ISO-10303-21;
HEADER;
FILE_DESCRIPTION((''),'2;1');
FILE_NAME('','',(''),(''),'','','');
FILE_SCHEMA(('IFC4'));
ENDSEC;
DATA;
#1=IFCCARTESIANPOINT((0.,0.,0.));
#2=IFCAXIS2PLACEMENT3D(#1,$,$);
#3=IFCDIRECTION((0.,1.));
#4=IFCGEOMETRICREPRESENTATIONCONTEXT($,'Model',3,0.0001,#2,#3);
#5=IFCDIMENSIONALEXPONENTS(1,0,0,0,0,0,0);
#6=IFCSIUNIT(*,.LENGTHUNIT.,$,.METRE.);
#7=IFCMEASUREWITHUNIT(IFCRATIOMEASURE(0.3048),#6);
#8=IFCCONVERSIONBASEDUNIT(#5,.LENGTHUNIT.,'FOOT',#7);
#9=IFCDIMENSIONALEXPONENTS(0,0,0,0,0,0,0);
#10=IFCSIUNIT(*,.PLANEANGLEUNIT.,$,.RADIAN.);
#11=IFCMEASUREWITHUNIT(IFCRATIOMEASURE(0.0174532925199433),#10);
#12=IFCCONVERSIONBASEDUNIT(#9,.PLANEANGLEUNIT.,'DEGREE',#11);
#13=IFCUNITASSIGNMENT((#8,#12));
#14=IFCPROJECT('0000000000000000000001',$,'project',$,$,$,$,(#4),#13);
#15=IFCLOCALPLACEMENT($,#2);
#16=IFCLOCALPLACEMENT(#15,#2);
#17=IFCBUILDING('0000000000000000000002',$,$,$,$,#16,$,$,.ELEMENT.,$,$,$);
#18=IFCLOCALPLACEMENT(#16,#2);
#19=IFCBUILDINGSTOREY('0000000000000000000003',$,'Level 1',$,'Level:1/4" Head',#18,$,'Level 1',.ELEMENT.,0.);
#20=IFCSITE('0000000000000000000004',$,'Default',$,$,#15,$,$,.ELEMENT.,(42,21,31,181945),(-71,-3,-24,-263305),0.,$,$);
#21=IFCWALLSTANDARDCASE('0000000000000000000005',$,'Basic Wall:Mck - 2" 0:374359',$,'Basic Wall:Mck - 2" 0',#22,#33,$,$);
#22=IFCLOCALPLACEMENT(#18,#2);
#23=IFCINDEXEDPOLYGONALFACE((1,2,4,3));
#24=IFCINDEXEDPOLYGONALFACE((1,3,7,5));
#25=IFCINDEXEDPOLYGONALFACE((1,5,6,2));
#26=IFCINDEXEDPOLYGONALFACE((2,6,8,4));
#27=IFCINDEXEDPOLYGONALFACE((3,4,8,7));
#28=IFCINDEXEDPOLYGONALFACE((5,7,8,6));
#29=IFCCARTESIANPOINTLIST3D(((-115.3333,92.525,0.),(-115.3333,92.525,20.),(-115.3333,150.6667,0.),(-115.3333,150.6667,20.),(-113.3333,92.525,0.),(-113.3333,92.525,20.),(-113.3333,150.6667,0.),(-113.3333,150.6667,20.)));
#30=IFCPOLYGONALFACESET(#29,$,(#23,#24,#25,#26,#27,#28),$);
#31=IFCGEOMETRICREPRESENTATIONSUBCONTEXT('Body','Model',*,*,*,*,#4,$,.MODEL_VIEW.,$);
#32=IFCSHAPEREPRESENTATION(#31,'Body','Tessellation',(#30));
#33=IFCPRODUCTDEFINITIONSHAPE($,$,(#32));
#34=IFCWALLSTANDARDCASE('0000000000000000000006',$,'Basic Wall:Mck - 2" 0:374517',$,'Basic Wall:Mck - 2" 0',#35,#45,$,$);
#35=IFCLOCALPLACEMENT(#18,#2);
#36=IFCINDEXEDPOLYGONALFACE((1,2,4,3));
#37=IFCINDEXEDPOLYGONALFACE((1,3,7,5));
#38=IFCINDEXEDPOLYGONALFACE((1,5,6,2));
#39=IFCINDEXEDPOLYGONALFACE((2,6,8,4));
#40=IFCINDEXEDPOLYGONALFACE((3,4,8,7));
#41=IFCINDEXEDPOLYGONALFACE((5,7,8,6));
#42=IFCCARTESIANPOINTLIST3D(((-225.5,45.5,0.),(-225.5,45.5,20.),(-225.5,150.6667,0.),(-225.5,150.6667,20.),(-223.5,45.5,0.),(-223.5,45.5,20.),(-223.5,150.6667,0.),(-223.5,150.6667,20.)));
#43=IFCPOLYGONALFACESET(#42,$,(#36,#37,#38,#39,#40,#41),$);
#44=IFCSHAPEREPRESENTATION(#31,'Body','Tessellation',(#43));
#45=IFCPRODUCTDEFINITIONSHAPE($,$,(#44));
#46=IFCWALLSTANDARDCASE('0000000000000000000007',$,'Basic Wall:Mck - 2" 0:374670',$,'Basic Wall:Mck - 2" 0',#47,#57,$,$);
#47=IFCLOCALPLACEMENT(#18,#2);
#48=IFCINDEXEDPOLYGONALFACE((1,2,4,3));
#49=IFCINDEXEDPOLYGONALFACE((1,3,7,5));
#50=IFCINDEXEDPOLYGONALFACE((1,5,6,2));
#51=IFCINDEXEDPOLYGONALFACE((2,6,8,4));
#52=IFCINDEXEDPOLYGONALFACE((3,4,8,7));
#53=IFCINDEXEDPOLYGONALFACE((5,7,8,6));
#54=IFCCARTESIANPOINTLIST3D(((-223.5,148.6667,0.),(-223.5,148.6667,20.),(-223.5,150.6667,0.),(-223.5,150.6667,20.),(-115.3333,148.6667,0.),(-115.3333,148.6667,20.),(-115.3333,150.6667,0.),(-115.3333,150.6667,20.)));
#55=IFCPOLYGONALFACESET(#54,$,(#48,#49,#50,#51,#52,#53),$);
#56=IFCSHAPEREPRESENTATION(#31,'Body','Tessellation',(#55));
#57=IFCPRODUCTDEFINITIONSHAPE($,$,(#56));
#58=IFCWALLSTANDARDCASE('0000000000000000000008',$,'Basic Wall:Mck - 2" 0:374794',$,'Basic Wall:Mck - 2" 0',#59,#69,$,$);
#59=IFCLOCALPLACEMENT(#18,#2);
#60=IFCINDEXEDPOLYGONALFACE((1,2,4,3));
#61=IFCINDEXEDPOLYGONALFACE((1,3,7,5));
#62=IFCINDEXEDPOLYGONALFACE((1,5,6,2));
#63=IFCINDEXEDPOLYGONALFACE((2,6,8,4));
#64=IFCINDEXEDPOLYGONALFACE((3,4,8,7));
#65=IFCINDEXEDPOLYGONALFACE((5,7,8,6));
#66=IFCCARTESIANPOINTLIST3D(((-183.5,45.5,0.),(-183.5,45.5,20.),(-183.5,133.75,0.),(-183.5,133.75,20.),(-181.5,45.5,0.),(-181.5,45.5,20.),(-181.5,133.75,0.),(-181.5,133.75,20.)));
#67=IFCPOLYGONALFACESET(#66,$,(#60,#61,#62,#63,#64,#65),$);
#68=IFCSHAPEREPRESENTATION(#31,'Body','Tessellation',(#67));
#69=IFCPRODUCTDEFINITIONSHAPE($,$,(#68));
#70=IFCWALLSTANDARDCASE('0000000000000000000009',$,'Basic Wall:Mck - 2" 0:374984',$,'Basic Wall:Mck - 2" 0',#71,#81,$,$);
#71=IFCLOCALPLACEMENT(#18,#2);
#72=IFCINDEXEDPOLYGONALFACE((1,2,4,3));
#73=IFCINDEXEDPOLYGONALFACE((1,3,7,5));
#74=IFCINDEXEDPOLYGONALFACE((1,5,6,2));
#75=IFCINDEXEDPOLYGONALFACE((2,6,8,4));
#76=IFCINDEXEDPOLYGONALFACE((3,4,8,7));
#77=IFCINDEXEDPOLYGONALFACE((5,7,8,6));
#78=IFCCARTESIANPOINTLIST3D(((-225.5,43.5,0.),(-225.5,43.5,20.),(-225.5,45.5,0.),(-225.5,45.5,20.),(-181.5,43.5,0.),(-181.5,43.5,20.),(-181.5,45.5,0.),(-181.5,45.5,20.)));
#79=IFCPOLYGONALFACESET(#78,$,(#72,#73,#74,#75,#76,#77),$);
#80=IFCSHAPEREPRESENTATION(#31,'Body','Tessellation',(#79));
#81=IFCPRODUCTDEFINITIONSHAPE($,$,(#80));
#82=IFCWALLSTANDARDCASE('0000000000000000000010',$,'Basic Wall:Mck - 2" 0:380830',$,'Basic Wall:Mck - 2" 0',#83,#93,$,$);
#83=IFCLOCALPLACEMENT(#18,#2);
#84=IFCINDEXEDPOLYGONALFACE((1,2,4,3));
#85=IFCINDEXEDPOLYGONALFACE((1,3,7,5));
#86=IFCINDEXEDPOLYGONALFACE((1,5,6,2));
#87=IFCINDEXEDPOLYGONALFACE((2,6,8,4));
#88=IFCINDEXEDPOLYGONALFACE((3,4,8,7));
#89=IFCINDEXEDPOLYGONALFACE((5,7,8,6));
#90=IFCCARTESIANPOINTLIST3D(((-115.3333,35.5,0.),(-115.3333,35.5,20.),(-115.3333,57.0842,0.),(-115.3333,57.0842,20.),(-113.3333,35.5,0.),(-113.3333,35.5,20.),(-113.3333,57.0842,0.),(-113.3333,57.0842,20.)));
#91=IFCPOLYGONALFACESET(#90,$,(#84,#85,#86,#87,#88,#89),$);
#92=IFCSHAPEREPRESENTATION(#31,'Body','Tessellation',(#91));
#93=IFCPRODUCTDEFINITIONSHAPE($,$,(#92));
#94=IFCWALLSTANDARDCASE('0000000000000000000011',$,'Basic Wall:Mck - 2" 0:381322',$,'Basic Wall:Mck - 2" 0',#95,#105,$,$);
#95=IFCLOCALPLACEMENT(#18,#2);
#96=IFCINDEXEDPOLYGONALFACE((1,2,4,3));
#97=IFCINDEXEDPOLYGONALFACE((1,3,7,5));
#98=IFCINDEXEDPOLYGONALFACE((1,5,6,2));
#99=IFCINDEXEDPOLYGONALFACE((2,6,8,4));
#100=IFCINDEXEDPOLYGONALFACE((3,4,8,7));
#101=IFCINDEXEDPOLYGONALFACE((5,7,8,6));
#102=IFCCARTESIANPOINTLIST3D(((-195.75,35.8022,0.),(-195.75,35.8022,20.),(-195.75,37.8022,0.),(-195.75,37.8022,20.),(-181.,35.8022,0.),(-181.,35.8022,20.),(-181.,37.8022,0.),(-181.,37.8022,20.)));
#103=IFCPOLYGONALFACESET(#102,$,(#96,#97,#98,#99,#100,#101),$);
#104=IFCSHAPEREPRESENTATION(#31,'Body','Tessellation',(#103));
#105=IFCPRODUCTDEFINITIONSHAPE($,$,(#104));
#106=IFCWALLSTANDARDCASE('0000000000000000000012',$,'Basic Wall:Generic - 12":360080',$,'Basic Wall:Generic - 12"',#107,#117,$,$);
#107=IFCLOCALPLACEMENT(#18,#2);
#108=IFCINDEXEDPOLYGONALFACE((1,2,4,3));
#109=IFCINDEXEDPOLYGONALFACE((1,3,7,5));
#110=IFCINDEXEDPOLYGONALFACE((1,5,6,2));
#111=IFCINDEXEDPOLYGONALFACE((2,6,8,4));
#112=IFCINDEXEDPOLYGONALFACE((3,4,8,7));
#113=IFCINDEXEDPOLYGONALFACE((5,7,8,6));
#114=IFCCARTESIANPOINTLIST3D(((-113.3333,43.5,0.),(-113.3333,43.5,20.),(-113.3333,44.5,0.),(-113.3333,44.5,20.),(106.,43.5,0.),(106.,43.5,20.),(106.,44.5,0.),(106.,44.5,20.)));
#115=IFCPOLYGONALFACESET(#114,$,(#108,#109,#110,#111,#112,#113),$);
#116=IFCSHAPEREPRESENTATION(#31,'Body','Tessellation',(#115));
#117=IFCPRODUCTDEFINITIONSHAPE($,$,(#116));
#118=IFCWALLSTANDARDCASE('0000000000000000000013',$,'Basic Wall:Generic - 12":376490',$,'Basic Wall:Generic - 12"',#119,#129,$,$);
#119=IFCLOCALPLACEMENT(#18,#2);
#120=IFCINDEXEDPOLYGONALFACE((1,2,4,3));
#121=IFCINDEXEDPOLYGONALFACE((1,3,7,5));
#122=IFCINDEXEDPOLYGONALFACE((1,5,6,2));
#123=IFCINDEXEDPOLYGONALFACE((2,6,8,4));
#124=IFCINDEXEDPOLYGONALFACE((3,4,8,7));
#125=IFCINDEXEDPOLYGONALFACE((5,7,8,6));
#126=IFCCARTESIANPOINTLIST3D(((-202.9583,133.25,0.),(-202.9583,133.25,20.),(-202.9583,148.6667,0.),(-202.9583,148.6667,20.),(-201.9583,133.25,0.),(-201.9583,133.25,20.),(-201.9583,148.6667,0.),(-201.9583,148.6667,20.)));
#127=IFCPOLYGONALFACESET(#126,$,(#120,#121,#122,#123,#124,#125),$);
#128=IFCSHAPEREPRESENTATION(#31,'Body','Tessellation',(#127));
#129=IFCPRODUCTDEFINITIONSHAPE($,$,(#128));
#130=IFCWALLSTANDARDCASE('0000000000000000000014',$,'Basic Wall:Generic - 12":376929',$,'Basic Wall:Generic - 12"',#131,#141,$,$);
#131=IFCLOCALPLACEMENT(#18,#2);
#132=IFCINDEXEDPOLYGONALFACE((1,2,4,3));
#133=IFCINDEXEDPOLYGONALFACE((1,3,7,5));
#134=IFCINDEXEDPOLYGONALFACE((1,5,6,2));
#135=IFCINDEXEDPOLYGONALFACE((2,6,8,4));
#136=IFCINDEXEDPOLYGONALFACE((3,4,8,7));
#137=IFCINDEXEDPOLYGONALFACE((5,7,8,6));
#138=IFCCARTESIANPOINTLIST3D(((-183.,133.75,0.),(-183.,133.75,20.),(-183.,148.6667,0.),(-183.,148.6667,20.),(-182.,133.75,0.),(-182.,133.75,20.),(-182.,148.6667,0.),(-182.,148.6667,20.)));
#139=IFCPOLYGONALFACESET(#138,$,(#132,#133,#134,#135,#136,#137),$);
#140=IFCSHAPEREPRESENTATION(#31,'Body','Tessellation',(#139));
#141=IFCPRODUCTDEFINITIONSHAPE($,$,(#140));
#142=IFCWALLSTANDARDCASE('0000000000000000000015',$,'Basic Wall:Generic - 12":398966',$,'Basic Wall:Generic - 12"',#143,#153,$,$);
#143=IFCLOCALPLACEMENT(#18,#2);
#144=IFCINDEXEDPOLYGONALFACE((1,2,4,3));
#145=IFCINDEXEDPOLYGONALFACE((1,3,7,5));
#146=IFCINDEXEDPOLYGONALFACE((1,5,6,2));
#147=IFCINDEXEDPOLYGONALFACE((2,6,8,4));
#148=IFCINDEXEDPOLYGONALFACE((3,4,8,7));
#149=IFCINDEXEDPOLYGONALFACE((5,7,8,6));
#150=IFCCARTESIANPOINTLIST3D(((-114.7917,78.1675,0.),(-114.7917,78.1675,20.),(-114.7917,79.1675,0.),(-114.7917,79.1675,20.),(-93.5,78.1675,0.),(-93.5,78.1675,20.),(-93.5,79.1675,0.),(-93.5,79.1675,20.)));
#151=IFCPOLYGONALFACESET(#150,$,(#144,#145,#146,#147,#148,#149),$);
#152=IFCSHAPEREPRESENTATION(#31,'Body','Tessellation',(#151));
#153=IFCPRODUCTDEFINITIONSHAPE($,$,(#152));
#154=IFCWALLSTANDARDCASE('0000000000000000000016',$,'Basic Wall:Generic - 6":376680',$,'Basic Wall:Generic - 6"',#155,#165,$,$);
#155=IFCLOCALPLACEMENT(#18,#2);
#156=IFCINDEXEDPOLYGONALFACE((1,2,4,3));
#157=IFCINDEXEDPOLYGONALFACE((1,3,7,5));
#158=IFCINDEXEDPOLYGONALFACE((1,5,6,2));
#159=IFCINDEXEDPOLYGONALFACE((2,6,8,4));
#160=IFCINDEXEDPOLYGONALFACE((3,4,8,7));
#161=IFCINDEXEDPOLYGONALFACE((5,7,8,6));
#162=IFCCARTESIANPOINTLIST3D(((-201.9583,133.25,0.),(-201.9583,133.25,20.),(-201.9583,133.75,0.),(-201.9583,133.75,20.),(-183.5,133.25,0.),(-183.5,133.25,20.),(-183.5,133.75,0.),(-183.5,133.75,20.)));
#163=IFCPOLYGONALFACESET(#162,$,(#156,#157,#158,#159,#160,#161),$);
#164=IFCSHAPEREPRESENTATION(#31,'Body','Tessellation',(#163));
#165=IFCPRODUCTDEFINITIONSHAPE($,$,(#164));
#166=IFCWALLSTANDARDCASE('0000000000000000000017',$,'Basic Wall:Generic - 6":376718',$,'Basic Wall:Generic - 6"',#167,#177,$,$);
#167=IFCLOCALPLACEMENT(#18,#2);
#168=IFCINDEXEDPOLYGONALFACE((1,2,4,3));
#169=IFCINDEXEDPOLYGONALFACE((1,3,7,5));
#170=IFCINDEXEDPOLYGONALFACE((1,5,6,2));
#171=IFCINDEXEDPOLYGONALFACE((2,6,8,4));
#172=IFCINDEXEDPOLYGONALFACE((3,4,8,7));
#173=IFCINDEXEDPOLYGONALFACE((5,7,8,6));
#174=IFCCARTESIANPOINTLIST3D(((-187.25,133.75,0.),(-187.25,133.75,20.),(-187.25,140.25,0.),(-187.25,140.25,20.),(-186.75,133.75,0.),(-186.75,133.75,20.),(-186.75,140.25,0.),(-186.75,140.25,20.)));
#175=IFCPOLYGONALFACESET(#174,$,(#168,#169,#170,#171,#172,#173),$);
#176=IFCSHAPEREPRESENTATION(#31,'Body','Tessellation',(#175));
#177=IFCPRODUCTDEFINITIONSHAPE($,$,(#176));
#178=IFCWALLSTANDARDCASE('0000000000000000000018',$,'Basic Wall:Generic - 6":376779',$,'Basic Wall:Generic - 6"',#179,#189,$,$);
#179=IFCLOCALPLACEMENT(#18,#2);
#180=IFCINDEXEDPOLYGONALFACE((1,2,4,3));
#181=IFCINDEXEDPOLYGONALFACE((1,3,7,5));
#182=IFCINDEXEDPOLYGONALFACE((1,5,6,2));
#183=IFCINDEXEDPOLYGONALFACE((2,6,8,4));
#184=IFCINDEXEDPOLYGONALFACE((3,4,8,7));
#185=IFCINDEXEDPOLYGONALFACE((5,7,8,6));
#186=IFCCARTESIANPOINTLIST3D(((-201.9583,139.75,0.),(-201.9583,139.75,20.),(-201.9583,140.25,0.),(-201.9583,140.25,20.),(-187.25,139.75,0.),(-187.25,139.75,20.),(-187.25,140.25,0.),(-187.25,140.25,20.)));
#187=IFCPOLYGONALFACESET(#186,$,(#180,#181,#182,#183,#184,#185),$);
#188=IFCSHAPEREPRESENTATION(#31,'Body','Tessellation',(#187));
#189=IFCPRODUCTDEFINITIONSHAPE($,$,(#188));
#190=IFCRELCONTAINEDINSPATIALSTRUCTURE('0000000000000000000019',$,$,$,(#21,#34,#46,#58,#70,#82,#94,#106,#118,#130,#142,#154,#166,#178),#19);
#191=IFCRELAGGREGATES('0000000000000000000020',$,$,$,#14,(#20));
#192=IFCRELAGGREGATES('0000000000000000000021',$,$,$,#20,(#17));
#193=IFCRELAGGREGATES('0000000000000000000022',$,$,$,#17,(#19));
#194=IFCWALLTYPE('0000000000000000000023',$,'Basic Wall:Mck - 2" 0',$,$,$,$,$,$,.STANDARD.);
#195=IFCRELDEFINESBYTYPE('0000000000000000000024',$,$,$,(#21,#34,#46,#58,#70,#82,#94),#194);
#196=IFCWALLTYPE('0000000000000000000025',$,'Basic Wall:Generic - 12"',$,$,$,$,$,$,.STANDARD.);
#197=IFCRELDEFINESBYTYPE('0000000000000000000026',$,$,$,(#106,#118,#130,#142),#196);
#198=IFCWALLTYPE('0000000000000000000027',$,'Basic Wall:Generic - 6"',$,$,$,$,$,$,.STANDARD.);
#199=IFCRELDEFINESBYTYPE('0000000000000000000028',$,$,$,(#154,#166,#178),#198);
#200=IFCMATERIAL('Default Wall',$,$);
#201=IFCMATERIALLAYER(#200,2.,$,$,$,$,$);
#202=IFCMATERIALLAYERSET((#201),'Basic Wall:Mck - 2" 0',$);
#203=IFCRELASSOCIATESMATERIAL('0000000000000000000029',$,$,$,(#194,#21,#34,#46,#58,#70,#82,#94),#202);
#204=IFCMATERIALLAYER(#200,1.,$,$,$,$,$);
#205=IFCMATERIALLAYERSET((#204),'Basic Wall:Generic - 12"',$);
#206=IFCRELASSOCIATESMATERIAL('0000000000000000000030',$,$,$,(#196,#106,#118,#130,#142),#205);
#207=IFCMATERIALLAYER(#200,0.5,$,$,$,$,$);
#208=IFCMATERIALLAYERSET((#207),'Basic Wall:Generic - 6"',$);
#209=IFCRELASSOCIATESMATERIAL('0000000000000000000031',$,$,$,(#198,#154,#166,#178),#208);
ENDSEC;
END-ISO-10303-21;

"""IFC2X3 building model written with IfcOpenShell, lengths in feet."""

from ifc_helpers import new_model, entity, si_unit, converted_unit, direction, frame, frame_2d, origin, place, context, subcontext, project, spatial, rectangle, extrude, material, layer, layer_set, layer_usage, type_object, element, save


model = new_model("IFC2X3")

# Units and contexts
model_context = context("Model", 3, precision=0.0001, world=origin(), true_north=direction((0.0, 1.0)))
body_context = subcontext(model_context, "Body", "Model", "MODEL_VIEW")
ifc_project = project(units=[converted_unit("LENGTHUNIT", "FOOT", entity("IfcRatioMeasure", 0.3048), si_unit("LENGTHUNIT", "METRE"), dimensions=[1, 0, 0, 0, 0, 0, 0]), converted_unit("PLANEANGLEUNIT", "DEGREE", entity("IfcRatioMeasure", 0.0174532925199433), si_unit("PLANEANGLEUNIT", "RADIAN"), dimensions=[0, 0, 0, 0, 0, 0, 0])], contexts=[model_context])

# Site, building, storey
site_placement = place(None, origin())
site = spatial("IfcSite", under=ifc_project, at=site_placement, Name="Default", CompositionType="ELEMENT", RefLatitude=(42, 21, 31, 181945), RefLongitude=(-71, -3, -24, -263305), RefElevation=0.0)
building_placement = place(site_placement, origin())
building = spatial("IfcBuilding", under=site, at=building_placement, CompositionType="ELEMENT")
storey_placement = place(building_placement, origin())
storey = spatial("IfcBuildingStorey", under=building, at=storey_placement, Name="Level 1", ObjectType="Level:1/4\" Head", LongName="Level 1", CompositionType="ELEMENT", Elevation=0.0)

# Walls
ifc_material = material(Name="Default Wall")
ifc_layer_1 = layer(ifc_material, 2.0)
ifc_layer_set_1 = layer_set([ifc_layer_1], Name="Basic Wall:Mck - 2\" 0")
ifc_layer_usage_1 = layer_usage(ifc_layer_set_1, "AXIS2", "NEGATIVE", 1.0)
wall_type_1 = type_object("IfcWallType", Name="Basic Wall:Mck - 2\" 0", PredefinedType="STANDARD", material=ifc_layer_set_1)
wall_1_placement = place(storey_placement, frame((-114.3333, 150.6667, 0.0), z_axis=(0.0, 0.0, 1.0), x_axis=(0.0, -1.0, 0.0)))
element("IfcWallStandardCase", 1, at=wall_1_placement, inside=storey, type_object=wall_type_1, material=ifc_layer_usage_1, Name="Basic Wall:Mck - 2\" 0:374359", ObjectType="Basic Wall:Mck - 2\" 0", context=body_context, shape_type="SweptSolid", body=[
    extrude(rectangle(XDim=58.1417, YDim=2.0, at=frame_2d((29.0708, 0.0), x_axis=(-1.0, 0.0))), origin(), (0.0, 0.0, 1.0), 20.0),
])
ifc_layer_usage_2 = layer_usage(ifc_layer_set_1, "AXIS2", "NEGATIVE", 1.0)
wall_2_placement = place(storey_placement, frame((-224.5, 150.6667, 0.0), z_axis=(0.0, 0.0, 1.0), x_axis=(0.0, -1.0, 0.0)))
element("IfcWallStandardCase", 2, at=wall_2_placement, inside=storey, type_object=wall_type_1, material=ifc_layer_usage_2, Name="Basic Wall:Mck - 2\" 0:374517", ObjectType="Basic Wall:Mck - 2\" 0", context=body_context, shape_type="SweptSolid", body=[
    extrude(rectangle(XDim=105.1667, YDim=2.0, at=frame_2d((52.5833, 0.0), x_axis=(-1.0, 0.0))), origin(), (0.0, 0.0, 1.0), 20.0),
])
ifc_layer_usage_3 = layer_usage(ifc_layer_set_1, "AXIS2", "NEGATIVE", 1.0)
wall_3_placement = place(storey_placement, frame((-223.5, 149.6667, 0.0)))
element("IfcWallStandardCase", 3, at=wall_3_placement, inside=storey, type_object=wall_type_1, material=ifc_layer_usage_3, Name="Basic Wall:Mck - 2\" 0:374670", ObjectType="Basic Wall:Mck - 2\" 0", context=body_context, shape_type="SweptSolid", body=[
    extrude(rectangle(XDim=108.1667, YDim=2.0, at=frame_2d((54.0833, 0.0), x_axis=(-1.0, 0.0))), origin(), (0.0, 0.0, 1.0), 20.0),
])
ifc_layer_usage_4 = layer_usage(ifc_layer_set_1, "AXIS2", "NEGATIVE", 1.0)
wall_4_placement = place(storey_placement, frame((-182.5, 133.75, 0.0), z_axis=(0.0, 0.0, 1.0), x_axis=(0.0, -1.0, 0.0)))
element("IfcWallStandardCase", 4, at=wall_4_placement, inside=storey, type_object=wall_type_1, material=ifc_layer_usage_4, Name="Basic Wall:Mck - 2\" 0:374794", ObjectType="Basic Wall:Mck - 2\" 0", context=body_context, shape_type="SweptSolid", body=[
    extrude(rectangle(XDim=88.25, YDim=2.0, at=frame_2d((44.125, 0.0), x_axis=(-1.0, 0.0))), origin(), (0.0, 0.0, 1.0), 20.0),
])
ifc_layer_usage_5 = layer_usage(ifc_layer_set_1, "AXIS2", "NEGATIVE", 1.0)
wall_5_placement = place(storey_placement, frame((-225.5, 44.5, 0.0)))
element("IfcWallStandardCase", 5, at=wall_5_placement, inside=storey, type_object=wall_type_1, material=ifc_layer_usage_5, Name="Basic Wall:Mck - 2\" 0:374984", ObjectType="Basic Wall:Mck - 2\" 0", context=body_context, shape_type="SweptSolid", body=[
    extrude(rectangle(XDim=44.0, YDim=2.0, at=frame_2d((22.0, 0.0), x_axis=(-1.0, 0.0))), origin(), (0.0, 0.0, 1.0), 20.0),
])
ifc_layer_usage_6 = layer_usage(ifc_layer_set_1, "AXIS2", "NEGATIVE", 1.0)
wall_6_placement = place(storey_placement, frame((-114.3333, 57.0842, 0.0), z_axis=(0.0, 0.0, 1.0), x_axis=(0.0, -1.0, 0.0)))
element("IfcWallStandardCase", 6, at=wall_6_placement, inside=storey, type_object=wall_type_1, material=ifc_layer_usage_6, Name="Basic Wall:Mck - 2\" 0:380830", ObjectType="Basic Wall:Mck - 2\" 0", context=body_context, shape_type="SweptSolid", body=[
    extrude(rectangle(XDim=21.5842, YDim=2.0, at=frame_2d((10.7921, 0.0), x_axis=(-1.0, 0.0))), origin(), (0.0, 0.0, 1.0), 20.0),
])
ifc_layer_usage_7 = layer_usage(ifc_layer_set_1, "AXIS2", "NEGATIVE", 1.0)
wall_7_placement = place(storey_placement, frame((-195.75, 36.8022, 0.0)))
element("IfcWallStandardCase", 7, at=wall_7_placement, inside=storey, type_object=wall_type_1, material=ifc_layer_usage_7, Name="Basic Wall:Mck - 2\" 0:381322", ObjectType="Basic Wall:Mck - 2\" 0", context=body_context, shape_type="SweptSolid", body=[
    extrude(rectangle(XDim=14.75, YDim=2.0, at=frame_2d((7.375, 0.0), x_axis=(-1.0, 0.0))), origin(), (0.0, 0.0, 1.0), 20.0),
])
ifc_layer_2 = layer(ifc_material, 1.0)
ifc_layer_set_2 = layer_set([ifc_layer_2], Name="Basic Wall:Generic - 12\"")
ifc_layer_usage_8 = layer_usage(ifc_layer_set_2, "AXIS2", "NEGATIVE", 0.5)
wall_type_2 = type_object("IfcWallType", Name="Basic Wall:Generic - 12\"", PredefinedType="STANDARD", material=ifc_layer_set_2)
wall_8_placement = place(storey_placement, frame((-113.3333, 44.0, 0.0)))
element("IfcWallStandardCase", 8, at=wall_8_placement, inside=storey, type_object=wall_type_2, material=ifc_layer_usage_8, Name="Basic Wall:Generic - 12\":360080", ObjectType="Basic Wall:Generic - 12\"", context=body_context, shape_type="SweptSolid", body=[
    extrude(rectangle(XDim=219.3333, YDim=1.0, at=frame_2d((109.6667, 0.0), x_axis=(-1.0, 0.0))), origin(), (0.0, 0.0, 1.0), 20.0),
])
ifc_layer_usage_9 = layer_usage(ifc_layer_set_2, "AXIS2", "NEGATIVE", 0.5)
wall_9_placement = place(storey_placement, frame((-202.4583, 148.6667, 0.0), z_axis=(0.0, 0.0, 1.0), x_axis=(0.0, -1.0, 0.0)))
element("IfcWallStandardCase", 9, at=wall_9_placement, inside=storey, type_object=wall_type_2, material=ifc_layer_usage_9, Name="Basic Wall:Generic - 12\":376490", ObjectType="Basic Wall:Generic - 12\"", context=body_context, shape_type="SweptSolid", body=[
    extrude(rectangle(XDim=15.4167, YDim=1.0, at=frame_2d((7.7083, 0.0), x_axis=(-1.0, 0.0))), origin(), (0.0, 0.0, 1.0), 20.0),
])
ifc_layer_usage_10 = layer_usage(ifc_layer_set_2, "AXIS2", "NEGATIVE", 0.5)
wall_10_placement = place(storey_placement, frame((-182.5, 148.6667, 0.0), z_axis=(0.0, 0.0, 1.0), x_axis=(0.0, -1.0, 0.0)))
element("IfcWallStandardCase", 10, at=wall_10_placement, inside=storey, type_object=wall_type_2, material=ifc_layer_usage_10, Name="Basic Wall:Generic - 12\":376929", ObjectType="Basic Wall:Generic - 12\"", context=body_context, shape_type="SweptSolid", body=[
    extrude(rectangle(XDim=14.9167, YDim=1.0, at=frame_2d((7.4583, 0.0), x_axis=(-1.0, 0.0))), origin(), (0.0, 0.0, 1.0), 20.0),
])
ifc_layer_usage_11 = layer_usage(ifc_layer_set_2, "AXIS2", "NEGATIVE", 0.5)
wall_11_placement = place(storey_placement, frame((-114.7917, 78.6675, 0.0)))
element("IfcWallStandardCase", 11, at=wall_11_placement, inside=storey, type_object=wall_type_2, material=ifc_layer_usage_11, Name="Basic Wall:Generic - 12\":398966", ObjectType="Basic Wall:Generic - 12\"", context=body_context, shape_type="SweptSolid", body=[
    extrude(rectangle(XDim=21.2917, YDim=1.0, at=frame_2d((10.6458, 0.0), x_axis=(-1.0, 0.0))), origin(), (0.0, 0.0, 1.0), 20.0),
])
ifc_layer_3 = layer(ifc_material, 0.5)
ifc_layer_set_3 = layer_set([ifc_layer_3], Name="Basic Wall:Generic - 6\"")
ifc_layer_usage_12 = layer_usage(ifc_layer_set_3, "AXIS2", "NEGATIVE", 0.25)
wall_type_3 = type_object("IfcWallType", Name="Basic Wall:Generic - 6\"", PredefinedType="STANDARD", material=ifc_layer_set_3)
wall_12_placement = place(storey_placement, frame((-201.9583, 133.5, 0.0)))
element("IfcWallStandardCase", 12, at=wall_12_placement, inside=storey, type_object=wall_type_3, material=ifc_layer_usage_12, Name="Basic Wall:Generic - 6\":376680", ObjectType="Basic Wall:Generic - 6\"", context=body_context, shape_type="SweptSolid", body=[
    extrude(rectangle(XDim=18.4583, YDim=0.5, at=frame_2d((9.2292, 0.0), x_axis=(-1.0, 0.0))), origin(), (0.0, 0.0, 1.0), 20.0),
])
ifc_layer_usage_13 = layer_usage(ifc_layer_set_3, "AXIS2", "NEGATIVE", 0.25)
wall_13_placement = place(storey_placement, frame((-187.0, 133.75, 0.0), z_axis=(0.0, 0.0, 1.0), x_axis=(0.0, 1.0, 0.0)))
element("IfcWallStandardCase", 13, at=wall_13_placement, inside=storey, type_object=wall_type_3, material=ifc_layer_usage_13, Name="Basic Wall:Generic - 6\":376718", ObjectType="Basic Wall:Generic - 6\"", context=body_context, shape_type="SweptSolid", body=[
    extrude(rectangle(XDim=6.5, YDim=0.5, at=frame_2d((3.25, 0.0), x_axis=(-1.0, 0.0))), origin(), (0.0, 0.0, 1.0), 20.0),
])
ifc_layer_usage_14 = layer_usage(ifc_layer_set_3, "AXIS2", "NEGATIVE", 0.25)
wall_14_placement = place(storey_placement, frame((-187.25, 140.0, 0.0), z_axis=(0.0, 0.0, 1.0), x_axis=(-1.0, 0.0, 0.0)))
element("IfcWallStandardCase", 14, at=wall_14_placement, inside=storey, type_object=wall_type_3, material=ifc_layer_usage_14, Name="Basic Wall:Generic - 6\":376779", ObjectType="Basic Wall:Generic - 6\"", context=body_context, shape_type="SweptSolid", body=[
    extrude(rectangle(XDim=14.7083, YDim=0.5, at=frame_2d((7.3542, 0.0), x_axis=(-1.0, 0.0))), origin(), (0.0, 0.0, 1.0), 20.0),
])

save(model, "model.ifc")
